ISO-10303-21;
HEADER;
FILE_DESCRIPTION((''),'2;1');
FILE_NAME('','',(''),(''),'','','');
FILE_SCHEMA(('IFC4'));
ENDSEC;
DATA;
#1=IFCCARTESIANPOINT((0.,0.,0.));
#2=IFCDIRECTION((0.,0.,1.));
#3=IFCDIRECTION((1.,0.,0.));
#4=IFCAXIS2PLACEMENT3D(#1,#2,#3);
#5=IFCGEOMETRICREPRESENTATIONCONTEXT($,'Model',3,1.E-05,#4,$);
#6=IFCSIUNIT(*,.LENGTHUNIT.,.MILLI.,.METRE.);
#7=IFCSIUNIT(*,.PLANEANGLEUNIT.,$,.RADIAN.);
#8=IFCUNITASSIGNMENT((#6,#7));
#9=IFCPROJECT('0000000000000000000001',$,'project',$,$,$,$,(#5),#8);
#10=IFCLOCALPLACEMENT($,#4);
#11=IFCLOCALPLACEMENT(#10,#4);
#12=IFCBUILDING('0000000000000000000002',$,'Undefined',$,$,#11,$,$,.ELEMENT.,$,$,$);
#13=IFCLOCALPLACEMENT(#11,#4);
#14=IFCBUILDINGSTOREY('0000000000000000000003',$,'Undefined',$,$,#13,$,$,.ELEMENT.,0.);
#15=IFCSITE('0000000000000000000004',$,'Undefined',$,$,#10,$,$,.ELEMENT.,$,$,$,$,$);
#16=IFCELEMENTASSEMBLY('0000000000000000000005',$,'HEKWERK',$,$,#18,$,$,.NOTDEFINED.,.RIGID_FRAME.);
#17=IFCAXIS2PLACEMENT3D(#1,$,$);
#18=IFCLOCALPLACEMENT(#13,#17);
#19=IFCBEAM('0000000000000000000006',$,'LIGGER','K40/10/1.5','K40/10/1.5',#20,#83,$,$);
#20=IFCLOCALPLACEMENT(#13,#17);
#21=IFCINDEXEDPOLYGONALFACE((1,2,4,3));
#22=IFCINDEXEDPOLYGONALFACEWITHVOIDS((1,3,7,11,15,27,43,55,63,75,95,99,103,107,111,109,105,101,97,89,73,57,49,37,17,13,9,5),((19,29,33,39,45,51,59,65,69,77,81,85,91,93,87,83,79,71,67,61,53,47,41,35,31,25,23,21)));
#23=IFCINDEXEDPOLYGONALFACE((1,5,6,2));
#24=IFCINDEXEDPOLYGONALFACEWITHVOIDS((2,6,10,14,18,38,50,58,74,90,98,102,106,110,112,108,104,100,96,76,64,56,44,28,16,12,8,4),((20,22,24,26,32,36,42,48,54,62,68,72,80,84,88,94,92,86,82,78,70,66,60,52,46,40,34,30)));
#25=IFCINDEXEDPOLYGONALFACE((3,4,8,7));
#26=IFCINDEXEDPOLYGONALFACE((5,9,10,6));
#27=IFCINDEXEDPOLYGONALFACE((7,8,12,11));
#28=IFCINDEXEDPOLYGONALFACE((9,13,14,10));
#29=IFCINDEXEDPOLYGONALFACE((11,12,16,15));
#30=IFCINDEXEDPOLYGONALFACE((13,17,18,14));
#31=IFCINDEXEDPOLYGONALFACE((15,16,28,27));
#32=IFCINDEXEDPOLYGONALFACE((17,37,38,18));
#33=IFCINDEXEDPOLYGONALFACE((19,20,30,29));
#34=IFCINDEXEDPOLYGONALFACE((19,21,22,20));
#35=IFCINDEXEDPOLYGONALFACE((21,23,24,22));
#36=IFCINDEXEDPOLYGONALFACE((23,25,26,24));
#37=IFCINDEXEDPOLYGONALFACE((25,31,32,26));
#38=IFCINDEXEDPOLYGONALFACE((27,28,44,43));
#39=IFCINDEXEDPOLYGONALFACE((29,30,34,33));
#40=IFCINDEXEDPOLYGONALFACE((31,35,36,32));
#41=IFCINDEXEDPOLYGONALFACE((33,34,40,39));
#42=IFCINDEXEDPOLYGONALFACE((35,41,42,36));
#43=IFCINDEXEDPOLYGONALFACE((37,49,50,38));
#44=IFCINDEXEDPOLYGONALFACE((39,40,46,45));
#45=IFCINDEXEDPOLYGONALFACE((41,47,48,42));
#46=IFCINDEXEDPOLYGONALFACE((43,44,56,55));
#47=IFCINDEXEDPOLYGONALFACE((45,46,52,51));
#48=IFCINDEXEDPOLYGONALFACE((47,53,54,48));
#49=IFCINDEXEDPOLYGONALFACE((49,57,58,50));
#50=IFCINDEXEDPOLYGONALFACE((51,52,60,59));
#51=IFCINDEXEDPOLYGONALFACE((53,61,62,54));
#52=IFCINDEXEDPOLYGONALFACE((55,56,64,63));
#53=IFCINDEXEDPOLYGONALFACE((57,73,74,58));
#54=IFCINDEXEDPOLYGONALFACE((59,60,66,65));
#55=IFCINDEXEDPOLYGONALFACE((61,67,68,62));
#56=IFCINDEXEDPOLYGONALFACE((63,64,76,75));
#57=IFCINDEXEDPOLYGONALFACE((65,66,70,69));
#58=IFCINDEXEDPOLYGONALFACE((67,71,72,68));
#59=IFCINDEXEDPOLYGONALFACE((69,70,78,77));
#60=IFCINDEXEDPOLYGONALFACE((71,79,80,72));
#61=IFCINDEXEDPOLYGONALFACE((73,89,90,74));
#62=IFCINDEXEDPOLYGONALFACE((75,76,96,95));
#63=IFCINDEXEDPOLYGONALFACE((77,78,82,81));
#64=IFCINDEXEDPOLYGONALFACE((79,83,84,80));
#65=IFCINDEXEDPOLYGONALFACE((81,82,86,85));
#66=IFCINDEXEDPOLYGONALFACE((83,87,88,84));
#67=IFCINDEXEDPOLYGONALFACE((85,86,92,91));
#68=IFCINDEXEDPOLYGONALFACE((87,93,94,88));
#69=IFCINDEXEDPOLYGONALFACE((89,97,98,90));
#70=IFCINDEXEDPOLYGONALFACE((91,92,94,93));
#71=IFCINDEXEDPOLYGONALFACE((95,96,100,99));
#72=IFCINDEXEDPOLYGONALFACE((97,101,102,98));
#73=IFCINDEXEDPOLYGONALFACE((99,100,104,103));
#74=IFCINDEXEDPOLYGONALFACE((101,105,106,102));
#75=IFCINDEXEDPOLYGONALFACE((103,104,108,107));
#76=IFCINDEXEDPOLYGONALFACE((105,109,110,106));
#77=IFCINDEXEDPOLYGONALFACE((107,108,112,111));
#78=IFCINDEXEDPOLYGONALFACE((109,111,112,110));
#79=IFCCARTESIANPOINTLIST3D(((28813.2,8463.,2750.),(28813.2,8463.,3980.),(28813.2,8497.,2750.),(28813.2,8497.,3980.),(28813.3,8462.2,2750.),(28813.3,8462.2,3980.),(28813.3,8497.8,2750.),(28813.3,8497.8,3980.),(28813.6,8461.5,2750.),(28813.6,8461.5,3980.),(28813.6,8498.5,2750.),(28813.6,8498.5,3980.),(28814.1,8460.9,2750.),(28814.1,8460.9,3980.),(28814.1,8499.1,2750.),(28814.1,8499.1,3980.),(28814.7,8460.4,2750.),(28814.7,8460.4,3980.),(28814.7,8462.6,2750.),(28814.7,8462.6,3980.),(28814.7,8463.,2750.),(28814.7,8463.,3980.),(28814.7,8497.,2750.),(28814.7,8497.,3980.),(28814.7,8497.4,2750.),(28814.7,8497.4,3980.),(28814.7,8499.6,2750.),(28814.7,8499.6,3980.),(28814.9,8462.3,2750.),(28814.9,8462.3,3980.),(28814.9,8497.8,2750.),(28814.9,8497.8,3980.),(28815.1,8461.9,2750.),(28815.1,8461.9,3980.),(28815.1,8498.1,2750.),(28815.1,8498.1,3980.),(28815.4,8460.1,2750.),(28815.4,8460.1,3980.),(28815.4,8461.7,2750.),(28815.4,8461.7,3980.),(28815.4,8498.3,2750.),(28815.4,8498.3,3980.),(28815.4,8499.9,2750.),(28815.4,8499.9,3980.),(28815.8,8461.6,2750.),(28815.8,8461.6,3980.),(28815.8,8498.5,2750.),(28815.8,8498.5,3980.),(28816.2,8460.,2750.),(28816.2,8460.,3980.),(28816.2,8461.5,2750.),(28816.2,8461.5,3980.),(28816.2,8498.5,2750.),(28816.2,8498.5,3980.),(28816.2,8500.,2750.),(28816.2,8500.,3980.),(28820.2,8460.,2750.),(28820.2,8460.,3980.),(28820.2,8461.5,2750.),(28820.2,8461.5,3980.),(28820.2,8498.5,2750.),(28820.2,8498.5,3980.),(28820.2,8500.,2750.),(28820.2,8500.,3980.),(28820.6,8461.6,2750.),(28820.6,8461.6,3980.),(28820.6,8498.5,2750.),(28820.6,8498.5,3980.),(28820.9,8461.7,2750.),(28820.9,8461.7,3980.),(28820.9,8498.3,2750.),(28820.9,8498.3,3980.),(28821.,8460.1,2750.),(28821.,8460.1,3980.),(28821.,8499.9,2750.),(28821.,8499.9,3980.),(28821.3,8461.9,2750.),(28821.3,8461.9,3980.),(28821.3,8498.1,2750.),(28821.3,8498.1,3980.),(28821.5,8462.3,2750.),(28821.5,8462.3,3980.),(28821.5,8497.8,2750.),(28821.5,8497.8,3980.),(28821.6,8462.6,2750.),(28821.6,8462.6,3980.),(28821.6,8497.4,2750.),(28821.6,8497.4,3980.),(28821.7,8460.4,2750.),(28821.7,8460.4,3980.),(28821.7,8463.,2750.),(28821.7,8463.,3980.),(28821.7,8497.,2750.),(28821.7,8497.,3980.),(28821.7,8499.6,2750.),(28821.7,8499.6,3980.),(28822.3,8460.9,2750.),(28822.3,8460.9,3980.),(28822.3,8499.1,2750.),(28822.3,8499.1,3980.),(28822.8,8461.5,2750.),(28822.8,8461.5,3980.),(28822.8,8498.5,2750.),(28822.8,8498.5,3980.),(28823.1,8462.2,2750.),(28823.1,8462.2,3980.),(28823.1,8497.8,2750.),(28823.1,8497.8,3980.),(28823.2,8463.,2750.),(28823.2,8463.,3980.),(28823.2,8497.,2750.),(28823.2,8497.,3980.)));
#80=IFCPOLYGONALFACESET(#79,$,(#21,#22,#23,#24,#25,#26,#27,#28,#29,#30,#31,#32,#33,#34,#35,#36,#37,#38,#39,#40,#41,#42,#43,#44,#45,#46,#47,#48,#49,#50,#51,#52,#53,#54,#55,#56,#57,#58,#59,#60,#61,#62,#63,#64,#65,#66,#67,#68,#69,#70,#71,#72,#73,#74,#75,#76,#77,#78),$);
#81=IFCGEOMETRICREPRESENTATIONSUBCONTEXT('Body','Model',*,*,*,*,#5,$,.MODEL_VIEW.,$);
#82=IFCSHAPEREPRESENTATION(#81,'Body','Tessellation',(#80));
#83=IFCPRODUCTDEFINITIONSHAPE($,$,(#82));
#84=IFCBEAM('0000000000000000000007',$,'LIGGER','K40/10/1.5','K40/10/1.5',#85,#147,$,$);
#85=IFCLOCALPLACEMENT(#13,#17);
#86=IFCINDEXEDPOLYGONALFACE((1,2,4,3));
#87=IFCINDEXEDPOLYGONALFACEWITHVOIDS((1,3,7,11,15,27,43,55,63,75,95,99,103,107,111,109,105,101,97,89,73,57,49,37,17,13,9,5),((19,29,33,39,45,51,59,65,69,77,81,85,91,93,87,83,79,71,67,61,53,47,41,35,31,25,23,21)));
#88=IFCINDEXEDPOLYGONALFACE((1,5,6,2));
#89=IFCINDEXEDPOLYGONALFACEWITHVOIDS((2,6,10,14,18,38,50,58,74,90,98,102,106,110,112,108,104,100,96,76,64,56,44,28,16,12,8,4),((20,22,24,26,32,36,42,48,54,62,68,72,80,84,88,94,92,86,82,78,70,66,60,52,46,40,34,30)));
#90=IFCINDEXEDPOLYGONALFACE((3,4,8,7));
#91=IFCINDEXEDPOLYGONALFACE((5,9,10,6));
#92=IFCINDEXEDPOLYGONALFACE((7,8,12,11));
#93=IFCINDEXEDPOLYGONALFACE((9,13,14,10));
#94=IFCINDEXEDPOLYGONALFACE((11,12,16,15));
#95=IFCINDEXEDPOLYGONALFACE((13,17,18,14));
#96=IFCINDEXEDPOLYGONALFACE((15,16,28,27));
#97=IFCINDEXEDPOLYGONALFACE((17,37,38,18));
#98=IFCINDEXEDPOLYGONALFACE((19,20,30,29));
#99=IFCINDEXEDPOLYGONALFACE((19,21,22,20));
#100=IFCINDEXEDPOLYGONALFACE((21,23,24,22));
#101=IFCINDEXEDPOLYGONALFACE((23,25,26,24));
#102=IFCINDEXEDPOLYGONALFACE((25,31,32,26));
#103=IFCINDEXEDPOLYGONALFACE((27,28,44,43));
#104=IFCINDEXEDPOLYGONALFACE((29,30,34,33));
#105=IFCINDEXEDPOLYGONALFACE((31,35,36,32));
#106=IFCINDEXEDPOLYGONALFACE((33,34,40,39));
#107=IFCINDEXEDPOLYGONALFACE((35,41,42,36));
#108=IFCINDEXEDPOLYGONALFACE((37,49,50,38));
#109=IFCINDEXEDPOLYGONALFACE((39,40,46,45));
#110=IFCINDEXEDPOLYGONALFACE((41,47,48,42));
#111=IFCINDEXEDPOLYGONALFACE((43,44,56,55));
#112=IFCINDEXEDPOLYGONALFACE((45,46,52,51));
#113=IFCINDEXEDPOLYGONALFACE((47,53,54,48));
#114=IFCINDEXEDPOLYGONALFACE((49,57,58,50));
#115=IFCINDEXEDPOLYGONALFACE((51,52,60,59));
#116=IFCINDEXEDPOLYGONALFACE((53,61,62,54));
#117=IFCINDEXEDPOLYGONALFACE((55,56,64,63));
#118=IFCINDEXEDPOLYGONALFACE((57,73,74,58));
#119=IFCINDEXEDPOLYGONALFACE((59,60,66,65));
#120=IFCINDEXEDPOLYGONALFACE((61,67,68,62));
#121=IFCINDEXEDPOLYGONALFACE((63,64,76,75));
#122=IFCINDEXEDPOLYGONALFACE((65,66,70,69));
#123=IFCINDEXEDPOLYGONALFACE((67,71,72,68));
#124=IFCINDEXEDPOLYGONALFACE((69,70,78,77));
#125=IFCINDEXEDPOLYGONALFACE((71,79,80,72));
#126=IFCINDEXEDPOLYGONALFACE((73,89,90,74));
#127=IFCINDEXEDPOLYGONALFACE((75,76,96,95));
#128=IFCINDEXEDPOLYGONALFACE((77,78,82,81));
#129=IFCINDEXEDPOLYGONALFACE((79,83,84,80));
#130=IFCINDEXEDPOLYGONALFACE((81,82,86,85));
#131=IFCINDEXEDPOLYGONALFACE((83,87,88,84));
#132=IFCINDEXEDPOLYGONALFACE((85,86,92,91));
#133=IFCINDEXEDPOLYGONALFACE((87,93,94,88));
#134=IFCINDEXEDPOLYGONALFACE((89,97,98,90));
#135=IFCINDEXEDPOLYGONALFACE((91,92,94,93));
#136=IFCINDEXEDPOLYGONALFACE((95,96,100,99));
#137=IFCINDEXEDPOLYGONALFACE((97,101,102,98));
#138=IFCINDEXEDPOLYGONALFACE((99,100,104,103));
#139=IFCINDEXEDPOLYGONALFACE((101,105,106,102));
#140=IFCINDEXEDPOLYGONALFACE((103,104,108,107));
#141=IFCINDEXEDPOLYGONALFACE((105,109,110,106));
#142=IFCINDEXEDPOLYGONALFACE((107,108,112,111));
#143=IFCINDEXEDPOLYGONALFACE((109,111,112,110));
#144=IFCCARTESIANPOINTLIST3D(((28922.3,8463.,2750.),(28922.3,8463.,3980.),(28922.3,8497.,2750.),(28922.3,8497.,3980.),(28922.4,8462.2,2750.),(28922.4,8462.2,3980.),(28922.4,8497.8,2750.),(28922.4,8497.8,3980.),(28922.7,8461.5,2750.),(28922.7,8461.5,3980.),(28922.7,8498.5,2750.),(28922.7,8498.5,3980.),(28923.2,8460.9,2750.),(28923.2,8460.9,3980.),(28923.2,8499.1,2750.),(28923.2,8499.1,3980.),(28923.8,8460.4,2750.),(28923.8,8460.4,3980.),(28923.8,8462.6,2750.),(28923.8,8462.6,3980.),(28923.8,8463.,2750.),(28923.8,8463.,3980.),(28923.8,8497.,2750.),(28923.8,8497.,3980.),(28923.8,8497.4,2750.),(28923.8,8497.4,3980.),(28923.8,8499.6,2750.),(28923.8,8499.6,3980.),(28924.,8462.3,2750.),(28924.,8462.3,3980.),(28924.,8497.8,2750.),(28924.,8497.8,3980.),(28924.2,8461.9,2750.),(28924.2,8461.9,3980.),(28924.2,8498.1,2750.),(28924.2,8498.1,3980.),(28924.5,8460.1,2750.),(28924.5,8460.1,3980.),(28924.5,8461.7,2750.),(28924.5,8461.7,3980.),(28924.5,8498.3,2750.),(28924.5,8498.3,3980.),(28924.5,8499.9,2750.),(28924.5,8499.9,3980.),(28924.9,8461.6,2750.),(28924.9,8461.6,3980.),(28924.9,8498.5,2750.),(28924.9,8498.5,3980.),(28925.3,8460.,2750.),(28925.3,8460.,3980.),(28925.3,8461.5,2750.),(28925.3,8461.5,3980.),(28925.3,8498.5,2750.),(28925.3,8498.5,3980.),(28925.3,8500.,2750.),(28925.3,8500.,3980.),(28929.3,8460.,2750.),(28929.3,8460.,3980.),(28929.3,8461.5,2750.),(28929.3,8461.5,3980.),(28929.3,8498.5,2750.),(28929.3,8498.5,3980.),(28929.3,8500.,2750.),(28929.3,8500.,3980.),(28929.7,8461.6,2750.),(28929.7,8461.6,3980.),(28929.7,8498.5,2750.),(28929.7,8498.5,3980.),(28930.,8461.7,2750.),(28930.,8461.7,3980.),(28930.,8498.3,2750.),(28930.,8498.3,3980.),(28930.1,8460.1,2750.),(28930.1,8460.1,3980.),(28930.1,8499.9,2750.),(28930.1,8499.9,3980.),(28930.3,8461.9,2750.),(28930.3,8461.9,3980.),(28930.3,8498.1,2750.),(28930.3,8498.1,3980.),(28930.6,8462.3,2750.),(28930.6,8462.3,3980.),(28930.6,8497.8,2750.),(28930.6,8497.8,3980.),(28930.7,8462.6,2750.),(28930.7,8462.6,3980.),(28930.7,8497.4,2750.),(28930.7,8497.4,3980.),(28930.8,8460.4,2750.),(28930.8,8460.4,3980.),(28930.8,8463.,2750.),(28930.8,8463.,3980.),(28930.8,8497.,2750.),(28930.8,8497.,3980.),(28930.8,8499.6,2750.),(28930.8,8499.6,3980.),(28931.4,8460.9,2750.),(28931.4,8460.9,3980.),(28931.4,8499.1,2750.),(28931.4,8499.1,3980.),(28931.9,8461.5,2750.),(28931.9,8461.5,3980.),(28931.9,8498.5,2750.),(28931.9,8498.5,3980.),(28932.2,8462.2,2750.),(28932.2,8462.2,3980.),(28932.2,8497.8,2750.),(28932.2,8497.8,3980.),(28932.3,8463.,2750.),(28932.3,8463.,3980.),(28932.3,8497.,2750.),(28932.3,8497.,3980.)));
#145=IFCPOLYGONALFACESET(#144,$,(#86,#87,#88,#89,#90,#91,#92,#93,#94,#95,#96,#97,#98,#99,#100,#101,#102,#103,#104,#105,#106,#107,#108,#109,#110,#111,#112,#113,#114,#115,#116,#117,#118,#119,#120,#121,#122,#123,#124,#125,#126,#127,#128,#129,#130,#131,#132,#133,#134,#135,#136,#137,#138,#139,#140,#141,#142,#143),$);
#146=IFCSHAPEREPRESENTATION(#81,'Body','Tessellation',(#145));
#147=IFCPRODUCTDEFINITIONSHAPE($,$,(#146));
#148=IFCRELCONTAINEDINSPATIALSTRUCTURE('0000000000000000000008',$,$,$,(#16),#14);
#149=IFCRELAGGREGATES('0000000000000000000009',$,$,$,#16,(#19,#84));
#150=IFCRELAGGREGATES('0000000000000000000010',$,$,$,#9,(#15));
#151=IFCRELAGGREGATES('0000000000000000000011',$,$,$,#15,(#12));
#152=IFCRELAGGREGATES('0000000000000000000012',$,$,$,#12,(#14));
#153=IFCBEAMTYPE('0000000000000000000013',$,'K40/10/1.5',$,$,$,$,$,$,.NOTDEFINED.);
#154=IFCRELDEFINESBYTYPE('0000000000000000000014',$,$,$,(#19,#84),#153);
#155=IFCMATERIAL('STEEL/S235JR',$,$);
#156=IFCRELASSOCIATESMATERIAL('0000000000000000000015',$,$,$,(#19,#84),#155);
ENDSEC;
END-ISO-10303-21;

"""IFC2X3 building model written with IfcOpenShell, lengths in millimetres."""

from ifc_helpers import new_model, si_unit, frame, origin_with_axes, origin_2d_with_axis, place, context, subcontext, project, spatial, hollow_rectangle, extrude, clip, halfspace, material, type_object, element, aggregate, save


model = new_model("IFC2X3")

# Units and contexts
model_context = context("Model", 3, precision=1e-05, world=origin_with_axes())
body_context = subcontext(model_context, "Body", "Model", "MODEL_VIEW")
ifc_project = project(units=[si_unit("LENGTHUNIT", "METRE", prefix="MILLI"), si_unit("PLANEANGLEUNIT", "RADIAN")], contexts=[model_context])

# Site, building, storey
site_placement = place(None, origin_with_axes())
site = spatial("IfcSite", under=ifc_project, at=site_placement, Name="Undefined", CompositionType="ELEMENT")
building_placement = place(site_placement, origin_with_axes())
building = spatial("IfcBuilding", under=site, at=building_placement, Name="Undefined", CompositionType="ELEMENT")
storey_placement = place(building_placement, origin_with_axes())
storey = spatial("IfcBuildingStorey", under=building, at=storey_placement, Name="Undefined", CompositionType="ELEMENT", Elevation=0.0)

# Element assembly
assembly_1_placement = place(storey_placement, origin_with_axes())
assembly_1 = element("IfcElementAssembly", 1, at=assembly_1_placement, inside=storey, Name="HEKWERK", AssemblyPlace="NOTDEFINED", PredefinedType="RIGID_FRAME")
ifc_material_1 = material(Name="STEEL/S235JR")
beam_type_1 = type_object("IfcBeamType", Name="K40/10/1.5", PredefinedType="NOTDEFINED")

# Beams
beam_1_placement = place(assembly_1_placement, frame((28818.2, 8480.0, 3980.0), z_axis=(0.0, 1.0, 0.0), x_axis=(0.0, 0.0, -1.0)))
beam_1 = element("IfcBeam", 2, at=beam_1_placement, type_object=beam_type_1, material=ifc_material_1, Name="LIGGER", Description="K40/10/1.5", ObjectType="K40/10/1.5", context=body_context, shape_type="Clipping", body=[
    clip(extrude(hollow_rectangle(XDim=10.0, YDim=40.0, WallThickness=1.5, InnerFilletRadius=1.5, OuterFilletRadius=3.0, at=origin_2d_with_axis()), frame((1230.0, 0.0, 0.0), z_axis=(-1.0, 0.0, 0.0), x_axis=(0.0, -1.0, 0.0)), (0.0, 0.0, 1.0), 1230.0), halfspace(frame((-7.0, -4.3, 47.4), z_axis=(-1.0, 0.0, 0.0), x_axis=(0.0, 0.768355, -0.640024)), False)),
])
beam_2_placement = place(assembly_1_placement, frame((28927.3, 8480.0, 3980.0), z_axis=(0.0, 1.0, 0.0), x_axis=(0.0, 0.0, -1.0)))
beam_2 = element("IfcBeam", 3, at=beam_2_placement, type_object=beam_type_1, material=ifc_material_1, Name="LIGGER", Description="K40/10/1.5", ObjectType="K40/10/1.5", context=body_context, shape_type="Clipping", body=[
    clip(extrude(hollow_rectangle(XDim=10.0, YDim=40.0, WallThickness=1.5, InnerFilletRadius=1.5, OuterFilletRadius=3.0, at=origin_2d_with_axis()), frame((1230.0, 0.0, 0.0), z_axis=(-1.0, 0.0, 0.0), x_axis=(0.0, -1.0, 0.0)), (0.0, 0.0, 1.0), 1230.0), halfspace(frame((-7.0, -4.3, 47.4), z_axis=(-1.0, 0.0, 0.0), x_axis=(0.0, 0.768355, -0.640024)), False)),
])

aggregate(assembly_1, [beam_1, beam_2])

save(model, "model.ifc")
